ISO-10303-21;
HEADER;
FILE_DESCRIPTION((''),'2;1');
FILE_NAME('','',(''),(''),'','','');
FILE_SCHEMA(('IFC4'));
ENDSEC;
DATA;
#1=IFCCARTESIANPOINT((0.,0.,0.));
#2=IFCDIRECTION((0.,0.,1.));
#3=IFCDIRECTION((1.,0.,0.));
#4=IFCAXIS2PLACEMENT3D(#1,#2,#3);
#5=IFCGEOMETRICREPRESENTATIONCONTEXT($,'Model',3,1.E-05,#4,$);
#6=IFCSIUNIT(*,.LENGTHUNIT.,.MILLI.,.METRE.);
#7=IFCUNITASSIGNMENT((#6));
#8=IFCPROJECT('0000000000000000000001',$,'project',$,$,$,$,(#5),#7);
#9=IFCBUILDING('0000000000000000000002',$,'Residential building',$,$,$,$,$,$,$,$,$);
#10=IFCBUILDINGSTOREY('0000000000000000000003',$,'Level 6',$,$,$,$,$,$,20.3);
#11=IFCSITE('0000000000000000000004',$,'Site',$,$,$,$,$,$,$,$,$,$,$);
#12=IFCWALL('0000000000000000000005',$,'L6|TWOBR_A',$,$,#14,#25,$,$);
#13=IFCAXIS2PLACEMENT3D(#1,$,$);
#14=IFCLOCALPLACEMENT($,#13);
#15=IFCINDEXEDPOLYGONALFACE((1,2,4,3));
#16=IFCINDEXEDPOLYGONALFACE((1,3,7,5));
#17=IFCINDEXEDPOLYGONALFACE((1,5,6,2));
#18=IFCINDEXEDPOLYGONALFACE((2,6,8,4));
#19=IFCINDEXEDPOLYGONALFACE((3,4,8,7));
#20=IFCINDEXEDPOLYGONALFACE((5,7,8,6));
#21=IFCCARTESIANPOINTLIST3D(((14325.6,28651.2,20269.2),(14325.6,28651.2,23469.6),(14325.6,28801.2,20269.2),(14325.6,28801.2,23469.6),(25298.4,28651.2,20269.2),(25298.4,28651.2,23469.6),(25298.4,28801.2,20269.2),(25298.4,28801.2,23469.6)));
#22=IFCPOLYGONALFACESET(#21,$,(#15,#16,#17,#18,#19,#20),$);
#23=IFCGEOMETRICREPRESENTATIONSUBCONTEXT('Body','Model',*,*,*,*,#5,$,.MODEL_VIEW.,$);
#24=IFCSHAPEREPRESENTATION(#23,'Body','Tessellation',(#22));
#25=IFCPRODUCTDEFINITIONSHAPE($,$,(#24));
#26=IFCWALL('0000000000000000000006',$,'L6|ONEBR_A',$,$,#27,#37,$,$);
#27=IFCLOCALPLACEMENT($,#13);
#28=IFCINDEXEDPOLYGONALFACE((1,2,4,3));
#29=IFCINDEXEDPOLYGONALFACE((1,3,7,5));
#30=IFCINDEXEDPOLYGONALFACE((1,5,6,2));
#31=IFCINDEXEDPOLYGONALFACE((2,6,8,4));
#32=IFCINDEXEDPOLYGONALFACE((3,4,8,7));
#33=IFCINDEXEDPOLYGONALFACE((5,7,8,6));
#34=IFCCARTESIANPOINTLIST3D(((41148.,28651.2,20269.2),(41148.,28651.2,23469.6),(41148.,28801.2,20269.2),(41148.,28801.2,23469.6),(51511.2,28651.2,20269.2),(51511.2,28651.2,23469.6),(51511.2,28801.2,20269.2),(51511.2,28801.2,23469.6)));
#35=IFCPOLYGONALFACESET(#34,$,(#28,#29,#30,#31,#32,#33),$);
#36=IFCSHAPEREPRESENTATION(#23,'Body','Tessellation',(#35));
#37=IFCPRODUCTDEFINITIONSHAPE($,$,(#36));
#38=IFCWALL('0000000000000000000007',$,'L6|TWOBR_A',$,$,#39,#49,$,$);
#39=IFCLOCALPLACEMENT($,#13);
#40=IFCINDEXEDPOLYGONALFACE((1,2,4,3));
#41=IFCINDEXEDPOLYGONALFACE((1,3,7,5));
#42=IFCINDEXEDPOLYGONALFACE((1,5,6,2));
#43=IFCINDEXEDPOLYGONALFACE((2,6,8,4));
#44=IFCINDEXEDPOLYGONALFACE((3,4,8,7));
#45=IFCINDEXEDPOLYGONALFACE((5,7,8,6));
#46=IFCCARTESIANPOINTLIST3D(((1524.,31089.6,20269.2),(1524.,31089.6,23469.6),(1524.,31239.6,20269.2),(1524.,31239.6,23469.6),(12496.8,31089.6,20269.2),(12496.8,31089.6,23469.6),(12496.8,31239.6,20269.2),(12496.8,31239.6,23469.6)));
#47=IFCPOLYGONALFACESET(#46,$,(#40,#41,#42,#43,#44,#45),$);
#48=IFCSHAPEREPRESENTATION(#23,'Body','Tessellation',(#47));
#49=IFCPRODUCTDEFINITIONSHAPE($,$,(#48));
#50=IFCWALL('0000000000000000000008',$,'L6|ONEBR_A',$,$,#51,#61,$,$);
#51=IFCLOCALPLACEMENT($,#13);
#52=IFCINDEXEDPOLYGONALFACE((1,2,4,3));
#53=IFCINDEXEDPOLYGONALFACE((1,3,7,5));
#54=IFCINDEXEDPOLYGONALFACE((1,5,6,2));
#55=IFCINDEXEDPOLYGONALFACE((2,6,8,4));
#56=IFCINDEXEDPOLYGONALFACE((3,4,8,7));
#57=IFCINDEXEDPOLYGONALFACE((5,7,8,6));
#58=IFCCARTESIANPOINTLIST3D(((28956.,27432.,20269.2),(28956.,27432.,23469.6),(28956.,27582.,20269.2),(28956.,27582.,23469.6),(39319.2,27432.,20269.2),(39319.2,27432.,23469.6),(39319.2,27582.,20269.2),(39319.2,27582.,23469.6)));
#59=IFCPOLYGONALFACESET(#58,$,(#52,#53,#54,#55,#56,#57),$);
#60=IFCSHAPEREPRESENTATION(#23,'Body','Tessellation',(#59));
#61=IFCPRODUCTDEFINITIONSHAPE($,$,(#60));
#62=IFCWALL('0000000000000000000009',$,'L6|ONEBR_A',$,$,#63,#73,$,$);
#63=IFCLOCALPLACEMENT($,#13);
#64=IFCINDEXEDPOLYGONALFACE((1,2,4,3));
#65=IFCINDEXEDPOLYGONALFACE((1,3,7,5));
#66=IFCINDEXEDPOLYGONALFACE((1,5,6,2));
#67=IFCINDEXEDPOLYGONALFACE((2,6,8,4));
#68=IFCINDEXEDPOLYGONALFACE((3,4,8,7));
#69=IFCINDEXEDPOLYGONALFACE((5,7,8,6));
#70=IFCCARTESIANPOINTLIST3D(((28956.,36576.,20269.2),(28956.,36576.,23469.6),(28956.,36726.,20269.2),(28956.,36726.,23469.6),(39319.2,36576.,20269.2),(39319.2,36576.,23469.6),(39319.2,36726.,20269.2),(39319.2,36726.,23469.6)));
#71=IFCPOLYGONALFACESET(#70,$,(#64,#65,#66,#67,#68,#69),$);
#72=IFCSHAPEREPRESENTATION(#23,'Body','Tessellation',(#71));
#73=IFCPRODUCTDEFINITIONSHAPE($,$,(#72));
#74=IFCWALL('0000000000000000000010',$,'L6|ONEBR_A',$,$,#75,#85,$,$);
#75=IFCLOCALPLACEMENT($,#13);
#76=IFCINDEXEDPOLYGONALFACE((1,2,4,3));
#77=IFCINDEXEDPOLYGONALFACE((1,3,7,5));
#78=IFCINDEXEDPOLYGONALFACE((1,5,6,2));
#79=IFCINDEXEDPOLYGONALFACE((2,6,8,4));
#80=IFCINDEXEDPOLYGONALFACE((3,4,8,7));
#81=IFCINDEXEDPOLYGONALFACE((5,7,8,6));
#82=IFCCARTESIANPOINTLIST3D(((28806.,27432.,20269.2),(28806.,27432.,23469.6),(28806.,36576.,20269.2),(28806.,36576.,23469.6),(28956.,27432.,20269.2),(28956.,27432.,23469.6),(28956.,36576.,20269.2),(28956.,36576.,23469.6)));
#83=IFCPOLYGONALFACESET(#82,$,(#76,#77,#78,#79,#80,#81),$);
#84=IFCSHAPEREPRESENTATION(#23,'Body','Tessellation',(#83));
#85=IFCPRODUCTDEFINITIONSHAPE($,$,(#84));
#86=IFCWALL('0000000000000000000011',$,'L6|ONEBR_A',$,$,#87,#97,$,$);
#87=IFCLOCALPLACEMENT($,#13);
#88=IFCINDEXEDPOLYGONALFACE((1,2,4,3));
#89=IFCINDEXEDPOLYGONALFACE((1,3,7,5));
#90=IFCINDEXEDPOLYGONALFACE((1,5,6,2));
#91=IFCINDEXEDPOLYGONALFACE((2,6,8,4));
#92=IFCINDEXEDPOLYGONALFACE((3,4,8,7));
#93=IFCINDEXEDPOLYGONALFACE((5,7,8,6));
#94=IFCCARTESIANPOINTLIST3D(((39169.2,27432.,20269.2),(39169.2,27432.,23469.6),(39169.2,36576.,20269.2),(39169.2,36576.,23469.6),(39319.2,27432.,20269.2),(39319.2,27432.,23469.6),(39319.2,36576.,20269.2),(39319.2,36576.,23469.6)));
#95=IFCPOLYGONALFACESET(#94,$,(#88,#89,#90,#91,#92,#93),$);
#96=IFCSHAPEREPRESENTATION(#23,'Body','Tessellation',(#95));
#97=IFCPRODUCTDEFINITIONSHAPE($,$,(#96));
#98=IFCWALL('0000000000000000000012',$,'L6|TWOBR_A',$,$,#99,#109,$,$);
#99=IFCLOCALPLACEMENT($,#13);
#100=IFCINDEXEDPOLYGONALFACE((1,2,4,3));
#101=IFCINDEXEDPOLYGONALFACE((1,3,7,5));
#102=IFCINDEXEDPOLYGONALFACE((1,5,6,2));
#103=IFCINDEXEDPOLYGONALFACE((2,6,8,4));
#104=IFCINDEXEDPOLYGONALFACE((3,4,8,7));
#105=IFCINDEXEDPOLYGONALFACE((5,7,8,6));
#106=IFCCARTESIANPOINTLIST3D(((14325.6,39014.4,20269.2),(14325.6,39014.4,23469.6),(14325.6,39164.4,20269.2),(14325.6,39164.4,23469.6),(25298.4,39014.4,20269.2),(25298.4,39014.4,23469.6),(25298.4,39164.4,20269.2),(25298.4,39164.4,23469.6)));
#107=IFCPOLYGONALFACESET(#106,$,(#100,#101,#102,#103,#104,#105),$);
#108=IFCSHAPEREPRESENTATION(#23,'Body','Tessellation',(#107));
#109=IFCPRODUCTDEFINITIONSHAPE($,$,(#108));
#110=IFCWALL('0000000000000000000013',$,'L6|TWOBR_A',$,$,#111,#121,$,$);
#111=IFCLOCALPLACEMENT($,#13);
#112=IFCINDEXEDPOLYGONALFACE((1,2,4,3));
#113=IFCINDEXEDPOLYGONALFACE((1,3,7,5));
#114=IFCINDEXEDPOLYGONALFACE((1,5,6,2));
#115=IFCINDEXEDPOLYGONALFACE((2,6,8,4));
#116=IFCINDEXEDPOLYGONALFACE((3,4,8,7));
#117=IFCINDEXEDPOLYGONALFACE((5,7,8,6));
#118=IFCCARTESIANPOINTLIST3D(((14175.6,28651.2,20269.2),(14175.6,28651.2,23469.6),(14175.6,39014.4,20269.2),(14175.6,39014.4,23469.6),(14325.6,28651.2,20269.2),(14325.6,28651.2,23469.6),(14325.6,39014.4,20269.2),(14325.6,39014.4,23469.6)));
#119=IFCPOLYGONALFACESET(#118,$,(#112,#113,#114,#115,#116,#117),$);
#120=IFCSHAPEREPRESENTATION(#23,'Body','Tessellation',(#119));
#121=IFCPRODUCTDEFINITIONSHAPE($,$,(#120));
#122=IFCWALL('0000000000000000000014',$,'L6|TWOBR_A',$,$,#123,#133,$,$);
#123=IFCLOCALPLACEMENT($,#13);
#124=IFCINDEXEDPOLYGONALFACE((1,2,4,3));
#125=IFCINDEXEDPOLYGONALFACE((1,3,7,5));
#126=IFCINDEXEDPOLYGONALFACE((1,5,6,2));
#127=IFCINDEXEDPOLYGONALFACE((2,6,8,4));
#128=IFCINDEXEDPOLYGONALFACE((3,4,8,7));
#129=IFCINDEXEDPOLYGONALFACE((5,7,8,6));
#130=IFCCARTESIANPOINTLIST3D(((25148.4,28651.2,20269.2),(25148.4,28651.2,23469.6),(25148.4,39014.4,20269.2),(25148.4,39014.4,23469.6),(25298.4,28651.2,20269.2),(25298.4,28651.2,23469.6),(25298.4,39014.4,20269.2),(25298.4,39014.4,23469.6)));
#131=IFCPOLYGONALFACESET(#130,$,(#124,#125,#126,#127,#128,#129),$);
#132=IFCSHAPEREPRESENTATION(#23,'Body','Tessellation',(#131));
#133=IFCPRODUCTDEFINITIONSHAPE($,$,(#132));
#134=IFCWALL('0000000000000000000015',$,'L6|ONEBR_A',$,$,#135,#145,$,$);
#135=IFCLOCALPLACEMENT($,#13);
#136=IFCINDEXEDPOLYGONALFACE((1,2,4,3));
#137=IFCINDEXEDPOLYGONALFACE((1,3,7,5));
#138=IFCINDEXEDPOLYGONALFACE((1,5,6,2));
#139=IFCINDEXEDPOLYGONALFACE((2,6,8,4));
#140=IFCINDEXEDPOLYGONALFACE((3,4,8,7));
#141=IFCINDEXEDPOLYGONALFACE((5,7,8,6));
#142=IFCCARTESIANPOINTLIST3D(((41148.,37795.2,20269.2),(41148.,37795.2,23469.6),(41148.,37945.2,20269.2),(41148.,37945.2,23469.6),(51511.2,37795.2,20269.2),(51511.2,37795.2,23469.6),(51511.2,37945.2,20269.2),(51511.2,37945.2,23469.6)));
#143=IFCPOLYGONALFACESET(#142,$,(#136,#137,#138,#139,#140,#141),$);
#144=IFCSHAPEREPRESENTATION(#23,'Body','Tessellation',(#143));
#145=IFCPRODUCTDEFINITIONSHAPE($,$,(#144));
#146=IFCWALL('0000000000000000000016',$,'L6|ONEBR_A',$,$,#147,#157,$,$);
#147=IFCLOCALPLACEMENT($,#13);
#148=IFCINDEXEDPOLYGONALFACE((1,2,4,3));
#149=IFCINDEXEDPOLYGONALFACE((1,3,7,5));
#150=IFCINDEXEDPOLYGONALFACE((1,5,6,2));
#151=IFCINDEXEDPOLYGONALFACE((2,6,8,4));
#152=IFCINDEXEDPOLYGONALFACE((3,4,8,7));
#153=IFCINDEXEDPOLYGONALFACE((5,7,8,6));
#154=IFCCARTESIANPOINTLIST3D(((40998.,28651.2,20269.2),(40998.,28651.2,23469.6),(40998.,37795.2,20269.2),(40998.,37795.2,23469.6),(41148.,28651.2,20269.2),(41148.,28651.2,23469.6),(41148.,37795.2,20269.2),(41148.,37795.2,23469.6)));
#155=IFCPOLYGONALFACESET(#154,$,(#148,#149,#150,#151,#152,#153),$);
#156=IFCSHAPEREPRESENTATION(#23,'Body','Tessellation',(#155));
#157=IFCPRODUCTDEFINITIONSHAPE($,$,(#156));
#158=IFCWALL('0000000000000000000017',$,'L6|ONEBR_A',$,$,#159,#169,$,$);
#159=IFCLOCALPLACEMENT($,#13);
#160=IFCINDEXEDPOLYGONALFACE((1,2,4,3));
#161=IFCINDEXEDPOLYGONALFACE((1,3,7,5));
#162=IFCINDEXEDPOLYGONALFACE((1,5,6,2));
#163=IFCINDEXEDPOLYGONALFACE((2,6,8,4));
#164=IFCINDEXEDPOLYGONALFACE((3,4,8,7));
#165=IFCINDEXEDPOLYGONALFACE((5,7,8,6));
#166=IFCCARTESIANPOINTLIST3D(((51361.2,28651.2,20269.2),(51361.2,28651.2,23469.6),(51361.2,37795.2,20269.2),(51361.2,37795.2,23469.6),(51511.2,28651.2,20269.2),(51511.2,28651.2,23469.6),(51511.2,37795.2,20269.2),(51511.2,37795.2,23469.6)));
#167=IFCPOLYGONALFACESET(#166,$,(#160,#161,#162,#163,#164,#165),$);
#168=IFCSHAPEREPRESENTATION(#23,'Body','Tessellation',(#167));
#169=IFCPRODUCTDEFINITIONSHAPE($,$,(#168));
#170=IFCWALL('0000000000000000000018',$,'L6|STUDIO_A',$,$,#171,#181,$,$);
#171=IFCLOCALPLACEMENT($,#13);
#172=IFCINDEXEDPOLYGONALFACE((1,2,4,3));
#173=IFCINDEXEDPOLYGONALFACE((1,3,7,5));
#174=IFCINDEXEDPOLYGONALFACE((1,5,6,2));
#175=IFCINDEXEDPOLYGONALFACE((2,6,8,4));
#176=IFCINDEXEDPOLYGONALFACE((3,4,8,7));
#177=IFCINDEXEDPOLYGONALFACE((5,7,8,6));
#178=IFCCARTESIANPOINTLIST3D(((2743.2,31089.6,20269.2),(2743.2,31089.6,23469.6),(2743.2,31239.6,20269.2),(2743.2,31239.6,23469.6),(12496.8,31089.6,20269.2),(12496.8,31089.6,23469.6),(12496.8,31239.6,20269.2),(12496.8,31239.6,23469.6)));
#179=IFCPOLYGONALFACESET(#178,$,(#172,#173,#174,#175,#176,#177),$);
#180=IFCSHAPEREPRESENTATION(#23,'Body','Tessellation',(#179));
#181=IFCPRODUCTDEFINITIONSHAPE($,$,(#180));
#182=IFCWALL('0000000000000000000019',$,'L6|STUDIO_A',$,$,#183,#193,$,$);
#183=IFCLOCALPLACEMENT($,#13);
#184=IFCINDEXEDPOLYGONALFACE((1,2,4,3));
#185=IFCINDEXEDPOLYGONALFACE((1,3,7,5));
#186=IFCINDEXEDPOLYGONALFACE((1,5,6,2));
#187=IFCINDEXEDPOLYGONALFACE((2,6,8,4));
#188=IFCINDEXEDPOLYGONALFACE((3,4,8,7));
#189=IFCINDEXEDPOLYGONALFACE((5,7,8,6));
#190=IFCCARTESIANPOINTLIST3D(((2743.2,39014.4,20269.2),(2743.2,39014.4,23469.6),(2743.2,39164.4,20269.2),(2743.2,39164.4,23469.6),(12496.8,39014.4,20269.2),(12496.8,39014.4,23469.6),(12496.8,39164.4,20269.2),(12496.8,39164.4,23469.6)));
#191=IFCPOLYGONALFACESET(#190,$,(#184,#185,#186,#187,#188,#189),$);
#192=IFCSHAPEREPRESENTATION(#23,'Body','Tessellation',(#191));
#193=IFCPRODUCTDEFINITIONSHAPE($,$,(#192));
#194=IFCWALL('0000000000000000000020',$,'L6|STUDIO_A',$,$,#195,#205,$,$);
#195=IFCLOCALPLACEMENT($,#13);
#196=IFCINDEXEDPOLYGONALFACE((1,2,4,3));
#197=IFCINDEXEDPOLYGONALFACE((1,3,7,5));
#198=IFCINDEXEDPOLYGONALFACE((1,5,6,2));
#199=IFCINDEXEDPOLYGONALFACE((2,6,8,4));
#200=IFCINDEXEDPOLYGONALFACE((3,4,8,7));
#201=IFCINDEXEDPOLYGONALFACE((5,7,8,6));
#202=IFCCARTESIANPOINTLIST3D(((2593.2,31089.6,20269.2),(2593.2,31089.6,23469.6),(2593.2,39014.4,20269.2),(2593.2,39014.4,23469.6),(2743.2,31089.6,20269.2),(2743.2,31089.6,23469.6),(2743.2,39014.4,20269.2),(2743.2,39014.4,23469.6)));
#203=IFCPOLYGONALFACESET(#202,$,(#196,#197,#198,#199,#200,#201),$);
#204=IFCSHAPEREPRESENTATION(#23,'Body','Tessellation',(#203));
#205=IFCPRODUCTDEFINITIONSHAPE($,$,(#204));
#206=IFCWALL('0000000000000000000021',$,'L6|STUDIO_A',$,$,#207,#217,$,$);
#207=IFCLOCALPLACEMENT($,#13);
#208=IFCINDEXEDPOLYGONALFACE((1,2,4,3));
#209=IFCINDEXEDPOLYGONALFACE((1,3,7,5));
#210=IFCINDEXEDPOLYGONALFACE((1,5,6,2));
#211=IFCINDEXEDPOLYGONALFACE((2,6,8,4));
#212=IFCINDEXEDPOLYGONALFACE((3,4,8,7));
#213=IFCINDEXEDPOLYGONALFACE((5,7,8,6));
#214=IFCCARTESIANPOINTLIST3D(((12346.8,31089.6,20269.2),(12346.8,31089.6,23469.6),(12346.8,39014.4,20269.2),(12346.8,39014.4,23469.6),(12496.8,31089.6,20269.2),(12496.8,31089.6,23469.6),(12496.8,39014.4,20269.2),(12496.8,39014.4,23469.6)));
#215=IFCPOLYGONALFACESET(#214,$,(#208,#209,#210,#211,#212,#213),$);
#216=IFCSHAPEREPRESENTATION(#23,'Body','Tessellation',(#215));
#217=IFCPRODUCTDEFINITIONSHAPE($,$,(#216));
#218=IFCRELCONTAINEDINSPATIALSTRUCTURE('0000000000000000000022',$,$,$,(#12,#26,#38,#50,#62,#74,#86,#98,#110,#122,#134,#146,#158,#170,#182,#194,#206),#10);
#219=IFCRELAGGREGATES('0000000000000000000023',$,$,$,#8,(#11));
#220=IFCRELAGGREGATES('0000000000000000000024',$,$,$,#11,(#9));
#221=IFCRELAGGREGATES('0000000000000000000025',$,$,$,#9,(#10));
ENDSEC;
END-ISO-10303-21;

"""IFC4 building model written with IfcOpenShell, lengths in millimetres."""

from ifc_helpers import new_model, si_unit, frame, origin_with_axes, place, context, subcontext, project, spatial, indexed_curve, outline, extrude, element, save


model = new_model("IFC4")

# Units and contexts
model_context = context("Model", 3, precision=1e-05, world=origin_with_axes())
body_context = subcontext(model_context, "Body", "Model", "MODEL_VIEW")
ifc_project = project(units=[si_unit("LENGTHUNIT", "METRE", prefix="MILLI")], contexts=[model_context])

# Site, building, storey
site = spatial("IfcSite", under=ifc_project, Name="Site")
building = spatial("IfcBuilding", under=site, Name="Residential building")
storey = spatial("IfcBuildingStorey", under=building, Name="Level 6", Elevation=20.3)

# Walls
wall_1_placement = place(None, frame((14325.6, 28651.2, 20269.2), z_axis=(0.0, 0.0, 1.0), x_axis=(1.0, 0.0, 0.0)))
element("IfcWall", 1, at=wall_1_placement, inside=storey, Name="L6|TWOBR_A", context=body_context, shape_type="SweptSolid", body=[
    extrude(outline(indexed_curve([(0.0, 0.0), (0.0, 150.0), (10972.8, 150.0), (10972.8, 0.0), (0.0, 0.0)], self_intersect=False)), origin_with_axes(), (0.0, 0.0, 1.0), 3200.4),
])
wall_2_placement = place(None, frame((41148.0, 28651.2, 20269.2), z_axis=(0.0, 0.0, 1.0), x_axis=(1.0, 0.0, 0.0)))
element("IfcWall", 2, at=wall_2_placement, inside=storey, Name="L6|ONEBR_A", context=body_context, shape_type="SweptSolid", body=[
    extrude(outline(indexed_curve([(0.0, 0.0), (0.0, 150.0), (10363.2, 150.0), (10363.2, 0.0), (0.0, 0.0)], self_intersect=False)), origin_with_axes(), (0.0, 0.0, 1.0), 3200.4),
])
wall_3_placement = place(None, frame((1524.0, 31089.6, 20269.2), z_axis=(0.0, 0.0, 1.0), x_axis=(1.0, 0.0, 0.0)))
element("IfcWall", 3, at=wall_3_placement, inside=storey, Name="L6|TWOBR_A", context=body_context, shape_type="SweptSolid", body=[
    extrude(outline(indexed_curve([(0.0, 0.0), (0.0, 150.0), (10972.8, 150.0), (10972.8, 0.0), (0.0, 0.0)], self_intersect=False)), origin_with_axes(), (0.0, 0.0, 1.0), 3200.4),
])
for number, where, z_axis, x_axis, name in (
    (4, (28956.0, 27432.0, 20269.2), (0.0, 0.0, 1.0), (1.0, 0.0, 0.0), "L6|ONEBR_A"),
    (5, (28956.0, 36576.0, 20269.2), (0.0, 0.0, 1.0), (1.0, 0.0, 0.0), "L6|ONEBR_A"),
):
    element("IfcWall", number, at=place(None, frame(where, z_axis=z_axis, x_axis=x_axis)), inside=storey, Name=name, context=body_context, shape_type="SweptSolid", body=[
        extrude(outline(indexed_curve([(0.0, 0.0), (0.0, 150.0), (10363.2, 150.0), (10363.2, 0.0), (0.0, 0.0)], self_intersect=False)), origin_with_axes(), (0.0, 0.0, 1.0), 3200.4),
    ])
for number, where, z_axis, x_axis, name in (
    (6, (28956.0, 27432.0, 20269.2), (0.0, 0.0, 1.0), (0.0, 1.0, 0.0), "L6|ONEBR_A"),
    (7, (39319.2, 27432.0, 20269.2), (0.0, 0.0, 1.0), (0.0, 1.0, 0.0), "L6|ONEBR_A"),
):
    element("IfcWall", number, at=place(None, frame(where, z_axis=z_axis, x_axis=x_axis)), inside=storey, Name=name, context=body_context, shape_type="SweptSolid", body=[
        extrude(outline(indexed_curve([(0.0, 0.0), (0.0, 150.0), (9144.0, 150.0), (9144.0, 0.0), (0.0, 0.0)], self_intersect=False)), origin_with_axes(), (0.0, 0.0, 1.0), 3200.4),
    ])
for number, where, z_axis, x_axis, name in (
    (8, (14325.6, 39014.4, 20269.2), (0.0, 0.0, 1.0), (1.0, 0.0, 0.0), "L6|TWOBR_A"),
):
    element("IfcWall", number, at=place(None, frame(where, z_axis=z_axis, x_axis=x_axis)), inside=storey, Name=name, context=body_context, shape_type="SweptSolid", body=[
        extrude(outline(indexed_curve([(0.0, 0.0), (0.0, 150.0), (10972.8, 150.0), (10972.8, 0.0), (0.0, 0.0)], self_intersect=False)), origin_with_axes(), (0.0, 0.0, 1.0), 3200.4),
    ])
for number, where, z_axis, x_axis, name in (
    (9, (14325.6, 28651.2, 20269.2), (0.0, 0.0, 1.0), (0.0, 1.0, 0.0), "L6|TWOBR_A"),
    (10, (25298.4, 28651.2, 20269.2), (0.0, 0.0, 1.0), (0.0, 1.0, 0.0), "L6|TWOBR_A"),
    (11, (41148.0, 37795.2, 20269.2), (0.0, 0.0, 1.0), (1.0, 0.0, 0.0), "L6|ONEBR_A"),
):
    element("IfcWall", number, at=place(None, frame(where, z_axis=z_axis, x_axis=x_axis)), inside=storey, Name=name, context=body_context, shape_type="SweptSolid", body=[
        extrude(outline(indexed_curve([(0.0, 0.0), (0.0, 150.0), (10363.2, 150.0), (10363.2, 0.0), (0.0, 0.0)], self_intersect=False)), origin_with_axes(), (0.0, 0.0, 1.0), 3200.4),
    ])
for number, where, z_axis, x_axis, name in (
    (12, (41148.0, 28651.2, 20269.2), (0.0, 0.0, 1.0), (0.0, 1.0, 0.0), "L6|ONEBR_A"),
    (13, (51511.2, 28651.2, 20269.2), (0.0, 0.0, 1.0), (0.0, 1.0, 0.0), "L6|ONEBR_A"),
):
    element("IfcWall", number, at=place(None, frame(where, z_axis=z_axis, x_axis=x_axis)), inside=storey, Name=name, context=body_context, shape_type="SweptSolid", body=[
        extrude(outline(indexed_curve([(0.0, 0.0), (0.0, 150.0), (9144.0, 150.0), (9144.0, 0.0), (0.0, 0.0)], self_intersect=False)), origin_with_axes(), (0.0, 0.0, 1.0), 3200.4),
    ])
for number, where, z_axis, x_axis, name in (
    (14, (2743.2, 31089.6, 20269.2), (0.0, 0.0, 1.0), (1.0, 0.0, 0.0), "L6|STUDIO_A"),
    (15, (2743.2, 39014.4, 20269.2), (0.0, 0.0, 1.0), (1.0, 0.0, 0.0), "L6|STUDIO_A"),
):
    element("IfcWall", number, at=place(None, frame(where, z_axis=z_axis, x_axis=x_axis)), inside=storey, Name=name, context=body_context, shape_type="SweptSolid", body=[
        extrude(outline(indexed_curve([(0.0, 0.0), (0.0, 150.0), (9753.6, 150.0), (9753.6, 0.0), (0.0, 0.0)], self_intersect=False)), origin_with_axes(), (0.0, 0.0, 1.0), 3200.4),
    ])
for number, where, z_axis, x_axis, name in (
    (16, (2743.2, 31089.6, 20269.2), (0.0, 0.0, 1.0), (0.0, 1.0, 0.0), "L6|STUDIO_A"),
    (17, (12496.8, 31089.6, 20269.2), (0.0, 0.0, 1.0), (0.0, 1.0, 0.0), "L6|STUDIO_A"),
):
    element("IfcWall", number, at=place(None, frame(where, z_axis=z_axis, x_axis=x_axis)), inside=storey, Name=name, context=body_context, shape_type="SweptSolid", body=[
        extrude(outline(indexed_curve([(0.0, 0.0), (0.0, 150.0), (7924.8, 150.0), (7924.8, 0.0), (0.0, 0.0)], self_intersect=False)), origin_with_axes(), (0.0, 0.0, 1.0), 3200.4),
    ])

save(model, "model.ifc")
